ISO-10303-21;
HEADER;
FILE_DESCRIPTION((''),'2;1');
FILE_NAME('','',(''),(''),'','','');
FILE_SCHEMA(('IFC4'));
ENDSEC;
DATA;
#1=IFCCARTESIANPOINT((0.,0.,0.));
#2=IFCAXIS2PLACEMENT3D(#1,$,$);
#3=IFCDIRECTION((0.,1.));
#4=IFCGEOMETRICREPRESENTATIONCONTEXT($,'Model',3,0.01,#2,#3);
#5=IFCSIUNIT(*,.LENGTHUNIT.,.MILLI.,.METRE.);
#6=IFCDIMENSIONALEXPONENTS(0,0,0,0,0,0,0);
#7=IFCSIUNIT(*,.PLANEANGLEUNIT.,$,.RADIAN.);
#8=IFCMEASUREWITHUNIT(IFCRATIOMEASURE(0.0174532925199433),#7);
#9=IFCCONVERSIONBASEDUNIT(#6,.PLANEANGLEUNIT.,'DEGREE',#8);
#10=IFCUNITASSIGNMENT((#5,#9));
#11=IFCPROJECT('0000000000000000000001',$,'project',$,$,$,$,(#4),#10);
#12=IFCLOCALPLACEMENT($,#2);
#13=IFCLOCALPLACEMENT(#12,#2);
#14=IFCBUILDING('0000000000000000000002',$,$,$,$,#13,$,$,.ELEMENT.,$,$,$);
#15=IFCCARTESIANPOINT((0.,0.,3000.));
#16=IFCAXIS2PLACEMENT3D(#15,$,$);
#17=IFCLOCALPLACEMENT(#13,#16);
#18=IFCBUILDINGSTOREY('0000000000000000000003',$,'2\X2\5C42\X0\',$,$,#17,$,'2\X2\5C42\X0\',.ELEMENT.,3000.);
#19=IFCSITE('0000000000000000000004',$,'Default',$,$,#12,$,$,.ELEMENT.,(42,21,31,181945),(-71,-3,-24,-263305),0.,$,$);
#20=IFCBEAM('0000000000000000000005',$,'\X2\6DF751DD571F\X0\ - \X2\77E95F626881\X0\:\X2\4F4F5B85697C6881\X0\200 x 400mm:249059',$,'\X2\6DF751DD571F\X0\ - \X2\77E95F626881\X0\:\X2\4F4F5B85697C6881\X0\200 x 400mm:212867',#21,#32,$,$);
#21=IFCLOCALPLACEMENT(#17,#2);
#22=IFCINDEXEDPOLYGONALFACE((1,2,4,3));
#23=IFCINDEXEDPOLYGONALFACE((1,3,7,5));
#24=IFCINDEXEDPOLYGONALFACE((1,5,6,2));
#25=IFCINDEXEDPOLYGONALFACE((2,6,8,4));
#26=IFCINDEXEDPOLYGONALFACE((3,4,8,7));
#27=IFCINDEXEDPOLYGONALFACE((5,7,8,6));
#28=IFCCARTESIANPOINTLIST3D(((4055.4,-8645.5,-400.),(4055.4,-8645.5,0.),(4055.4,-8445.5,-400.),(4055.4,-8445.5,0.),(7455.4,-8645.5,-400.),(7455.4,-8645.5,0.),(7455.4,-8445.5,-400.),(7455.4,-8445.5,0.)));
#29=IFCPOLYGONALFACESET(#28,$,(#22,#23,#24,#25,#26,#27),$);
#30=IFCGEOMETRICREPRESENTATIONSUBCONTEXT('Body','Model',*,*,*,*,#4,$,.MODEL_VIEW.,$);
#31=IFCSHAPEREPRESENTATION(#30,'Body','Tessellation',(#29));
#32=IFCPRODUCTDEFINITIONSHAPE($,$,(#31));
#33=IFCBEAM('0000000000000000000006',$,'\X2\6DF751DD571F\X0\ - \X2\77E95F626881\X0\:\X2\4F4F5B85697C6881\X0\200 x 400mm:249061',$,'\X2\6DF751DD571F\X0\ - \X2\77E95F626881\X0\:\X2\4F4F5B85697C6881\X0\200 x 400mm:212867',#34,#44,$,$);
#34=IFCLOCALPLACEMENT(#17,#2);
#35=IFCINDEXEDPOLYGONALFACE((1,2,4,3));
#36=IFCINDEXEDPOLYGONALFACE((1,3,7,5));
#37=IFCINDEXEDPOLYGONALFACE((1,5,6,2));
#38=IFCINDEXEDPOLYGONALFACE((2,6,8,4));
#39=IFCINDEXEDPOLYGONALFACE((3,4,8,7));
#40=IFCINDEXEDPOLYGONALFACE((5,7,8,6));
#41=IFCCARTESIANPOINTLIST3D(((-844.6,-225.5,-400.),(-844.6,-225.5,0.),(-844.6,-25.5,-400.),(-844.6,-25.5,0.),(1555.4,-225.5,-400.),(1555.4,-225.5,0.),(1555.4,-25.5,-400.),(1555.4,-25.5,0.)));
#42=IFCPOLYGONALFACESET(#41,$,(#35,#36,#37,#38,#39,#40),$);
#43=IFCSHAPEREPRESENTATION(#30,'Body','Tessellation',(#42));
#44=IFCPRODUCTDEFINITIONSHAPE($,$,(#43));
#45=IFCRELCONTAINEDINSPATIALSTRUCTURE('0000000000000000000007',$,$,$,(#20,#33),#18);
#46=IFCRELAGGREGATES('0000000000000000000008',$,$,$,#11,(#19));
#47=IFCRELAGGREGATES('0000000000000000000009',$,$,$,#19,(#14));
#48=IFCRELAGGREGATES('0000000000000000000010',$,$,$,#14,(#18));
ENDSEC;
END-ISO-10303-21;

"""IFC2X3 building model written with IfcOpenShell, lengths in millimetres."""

from ifc_helpers import new_model, entity, si_unit, converted_unit, direction, frame, frame_2d, origin, place, context, subcontext, project, spatial, rectangle, extrude, element, save


model = new_model("IFC2X3")

# Units and contexts
model_context = context("Model", 3, precision=0.01, world=origin(), true_north=direction((0.0, 1.0)))
body_context = subcontext(model_context, "Body", "Model", "MODEL_VIEW")
ifc_project = project(units=[si_unit("LENGTHUNIT", "METRE", prefix="MILLI"), converted_unit("PLANEANGLEUNIT", "DEGREE", entity("IfcRatioMeasure", 0.0174532925199433), si_unit("PLANEANGLEUNIT", "RADIAN"), dimensions=[0, 0, 0, 0, 0, 0, 0])], contexts=[model_context])

# Site, building, storey
site_placement = place(None, origin())
site = spatial("IfcSite", under=ifc_project, at=site_placement, Name="Default", CompositionType="ELEMENT", RefLatitude=(42, 21, 31, 181945), RefLongitude=(-71, -3, -24, -263305), RefElevation=0.0)
building_placement = place(site_placement, origin())
building = spatial("IfcBuilding", under=site, at=building_placement, CompositionType="ELEMENT")
storey_placement = place(building_placement, frame((0.0, 0.0, 3000.0)))
storey = spatial("IfcBuildingStorey", under=building, at=storey_placement, Name="2层", LongName="2层", CompositionType="ELEMENT", Elevation=3000.0)

# Beams
beam_1_placement = place(storey_placement, frame((7555.4, -8545.5, 0.0), z_axis=(0.0, 0.0, 1.0), x_axis=(-1.0, 0.0, 0.0)))
element("IfcBeam", 1, at=beam_1_placement, inside=storey, Name="混凝土 - 矩形梁:住宅楼梁200 x 400mm:249059", ObjectType="混凝土 - 矩形梁:住宅楼梁200 x 400mm:212867", context=body_context, shape_type="SweptSolid", body=[
    extrude(rectangle(XDim=400.0, YDim=200.0, at=frame_2d((0.0, 0.0), x_axis=(1.0, 0.0))), frame((100.0, 0.0, -200.0), z_axis=(1.0, 0.0, 0.0), x_axis=(0.0, 0.0, -1.0)), (0.0, 0.0, 1.0), 3400.0),
])
beam_2_placement = place(storey_placement, frame((-944.6, -125.5, 0.0)))
element("IfcBeam", 2, at=beam_2_placement, inside=storey, Name="混凝土 - 矩形梁:住宅楼梁200 x 400mm:249061", ObjectType="混凝土 - 矩形梁:住宅楼梁200 x 400mm:212867", context=body_context, shape_type="SweptSolid", body=[
    extrude(rectangle(XDim=400.0, YDim=200.0, at=frame_2d((0.0, 0.0), x_axis=(1.0, 0.0))), frame((100.0, 0.0, -200.0), z_axis=(1.0, 0.0, 0.0), x_axis=(0.0, 0.0, -1.0)), (0.0, 0.0, 1.0), 2400.0),
])

save(model, "model.ifc")
